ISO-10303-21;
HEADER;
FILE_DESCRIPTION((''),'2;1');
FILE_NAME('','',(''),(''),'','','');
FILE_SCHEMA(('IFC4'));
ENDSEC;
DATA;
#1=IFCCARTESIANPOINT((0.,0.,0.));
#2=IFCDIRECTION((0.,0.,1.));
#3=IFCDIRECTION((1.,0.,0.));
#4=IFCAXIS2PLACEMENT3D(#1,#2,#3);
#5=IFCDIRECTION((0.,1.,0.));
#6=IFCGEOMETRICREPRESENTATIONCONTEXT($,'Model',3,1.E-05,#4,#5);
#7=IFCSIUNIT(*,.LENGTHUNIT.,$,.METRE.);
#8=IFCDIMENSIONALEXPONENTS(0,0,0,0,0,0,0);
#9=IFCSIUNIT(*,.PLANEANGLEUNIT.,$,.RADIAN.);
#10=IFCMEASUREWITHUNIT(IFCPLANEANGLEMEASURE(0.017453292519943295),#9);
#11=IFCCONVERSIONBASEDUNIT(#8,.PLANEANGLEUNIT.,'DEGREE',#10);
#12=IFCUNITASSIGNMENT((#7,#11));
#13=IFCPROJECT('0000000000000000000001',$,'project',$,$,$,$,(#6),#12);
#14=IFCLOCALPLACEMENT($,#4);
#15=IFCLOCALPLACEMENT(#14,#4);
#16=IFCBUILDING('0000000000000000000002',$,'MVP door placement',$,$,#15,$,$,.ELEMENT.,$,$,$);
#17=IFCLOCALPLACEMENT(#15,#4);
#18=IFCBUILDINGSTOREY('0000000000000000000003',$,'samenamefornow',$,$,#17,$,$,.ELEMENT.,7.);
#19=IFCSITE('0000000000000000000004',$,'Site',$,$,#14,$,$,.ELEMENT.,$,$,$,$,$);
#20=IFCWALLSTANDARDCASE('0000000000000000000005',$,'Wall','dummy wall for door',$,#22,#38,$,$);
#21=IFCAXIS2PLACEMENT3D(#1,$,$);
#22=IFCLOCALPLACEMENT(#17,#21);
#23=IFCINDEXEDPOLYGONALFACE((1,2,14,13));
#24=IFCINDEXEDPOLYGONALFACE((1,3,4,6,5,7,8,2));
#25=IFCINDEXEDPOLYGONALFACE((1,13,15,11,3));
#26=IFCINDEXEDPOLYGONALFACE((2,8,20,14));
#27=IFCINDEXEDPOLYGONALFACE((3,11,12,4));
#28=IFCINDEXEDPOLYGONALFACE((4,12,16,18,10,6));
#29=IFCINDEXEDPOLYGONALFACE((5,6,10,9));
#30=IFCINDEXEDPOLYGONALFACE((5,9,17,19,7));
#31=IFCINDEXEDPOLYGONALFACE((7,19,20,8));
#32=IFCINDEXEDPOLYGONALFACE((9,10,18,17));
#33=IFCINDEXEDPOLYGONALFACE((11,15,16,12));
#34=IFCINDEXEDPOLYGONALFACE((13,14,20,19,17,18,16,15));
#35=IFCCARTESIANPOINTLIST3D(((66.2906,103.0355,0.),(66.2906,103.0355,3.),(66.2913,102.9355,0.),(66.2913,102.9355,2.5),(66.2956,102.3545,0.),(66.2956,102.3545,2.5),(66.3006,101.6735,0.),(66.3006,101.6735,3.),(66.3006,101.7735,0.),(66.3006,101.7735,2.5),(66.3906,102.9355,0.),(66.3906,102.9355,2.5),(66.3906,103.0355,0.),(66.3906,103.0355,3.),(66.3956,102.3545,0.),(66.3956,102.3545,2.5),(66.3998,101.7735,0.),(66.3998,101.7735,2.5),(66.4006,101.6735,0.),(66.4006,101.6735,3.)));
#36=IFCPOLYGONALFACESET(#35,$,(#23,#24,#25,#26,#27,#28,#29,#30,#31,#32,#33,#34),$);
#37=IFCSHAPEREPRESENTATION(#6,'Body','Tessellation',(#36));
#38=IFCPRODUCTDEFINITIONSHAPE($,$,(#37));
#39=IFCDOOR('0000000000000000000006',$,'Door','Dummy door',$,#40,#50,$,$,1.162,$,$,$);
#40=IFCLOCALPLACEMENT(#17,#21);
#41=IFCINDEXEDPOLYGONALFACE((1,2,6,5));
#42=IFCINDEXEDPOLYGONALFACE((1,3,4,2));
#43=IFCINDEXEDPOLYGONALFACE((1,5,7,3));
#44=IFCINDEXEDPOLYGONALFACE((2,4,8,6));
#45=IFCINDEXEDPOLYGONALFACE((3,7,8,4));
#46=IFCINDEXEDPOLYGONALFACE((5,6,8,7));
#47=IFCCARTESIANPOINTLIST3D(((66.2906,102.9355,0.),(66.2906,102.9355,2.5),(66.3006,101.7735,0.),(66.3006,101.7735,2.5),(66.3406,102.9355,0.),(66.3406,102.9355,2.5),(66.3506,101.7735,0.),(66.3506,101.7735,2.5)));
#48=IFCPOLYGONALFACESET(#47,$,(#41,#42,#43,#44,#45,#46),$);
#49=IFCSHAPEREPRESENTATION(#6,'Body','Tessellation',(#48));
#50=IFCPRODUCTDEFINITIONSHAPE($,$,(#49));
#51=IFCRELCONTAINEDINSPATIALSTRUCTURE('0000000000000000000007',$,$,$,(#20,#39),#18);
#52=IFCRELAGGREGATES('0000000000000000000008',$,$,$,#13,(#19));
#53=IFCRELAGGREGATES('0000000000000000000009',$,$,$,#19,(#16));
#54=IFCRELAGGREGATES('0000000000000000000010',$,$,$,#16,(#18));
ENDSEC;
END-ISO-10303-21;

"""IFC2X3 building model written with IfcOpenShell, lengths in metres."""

from ifc_helpers import new_model, entity, si_unit, converted_unit, direction, origin_with_axes, place, context, project, spatial, polyline, outline, extrude, element, fill, save


model = new_model("IFC2X3")

# Units and contexts
model_context = context("Model", 3, precision=1e-05, world=origin_with_axes(), true_north=direction((0.0, 1.0, 0.0)))
ifc_project = project(units=[si_unit("LENGTHUNIT", "METRE"), converted_unit("PLANEANGLEUNIT", "DEGREE", entity("IfcPlaneAngleMeasure", 0.017453292519943295), si_unit("PLANEANGLEUNIT", "RADIAN"), dimensions=[0, 0, 0, 0, 0, 0, 0])], contexts=[model_context])

# Site, building, storey
site_placement = place(None, origin_with_axes())
site = spatial("IfcSite", under=ifc_project, at=site_placement, Name="Site", CompositionType="ELEMENT")
building_placement = place(site_placement, origin_with_axes())
building = spatial("IfcBuilding", under=site, at=building_placement, Name="MVP door placement", CompositionType="ELEMENT")
storey_placement = place(building_placement, origin_with_axes())
storey = spatial("IfcBuildingStorey", under=building, at=storey_placement, Name="samenamefornow", CompositionType="ELEMENT", Elevation=7.0)

# Wall, opening, door
wall_1_placement = place(storey_placement, origin_with_axes())
wall_1 = element("IfcWallStandardCase", 1, at=wall_1_placement, inside=storey, Name="Wall", Description="dummy wall for door", context=model_context, shape_type="SweptSolid", body=[
    extrude(outline(polyline([(66.2906, 103.0355, 0.0), (66.3006, 101.6735, 0.0), (66.4006, 101.6735, 0.0), (66.3906, 103.0355, 0.0), (66.2906, 103.0355, 0.0)])), origin_with_axes(), (0.0, 0.0, 1.0), 3.0),
])
opening_1_placement = place(wall_1_placement, origin_with_axes())
opening_1 = element("IfcOpeningElement", 2, at=opening_1_placement, cuts=wall_1, context=model_context, shape_type="SweptSolid", body=[
    extrude(outline(polyline([(66.2906, 102.9355, 0.0), (66.3006, 101.7735, 0.0), (66.4006, 101.7735, 0.0), (66.3906, 102.9355, 0.0), (66.2906, 102.9355, 0.0)])), origin_with_axes(), (0.0, 0.0, 1.0), 2.5),
])
door_1_placement = place(opening_1_placement, origin_with_axes())
door_1 = element("IfcDoor", 3, at=door_1_placement, inside=storey, Name="Door", Description="Dummy door", OverallWidth=1.162, context=model_context, shape_type="SweptSolid", body=[
    extrude(outline(polyline([(66.2906, 102.9355, 0.0), (66.3006, 101.7735, 0.0), (66.3506, 101.7735, 0.0), (66.3406, 102.9355, 0.0), (66.2906, 102.9355, 0.0)])), origin_with_axes(), (0.0, 0.0, 1.0), 2.5),
])
fill(opening_1, door_1)

save(model, "model.ifc")
